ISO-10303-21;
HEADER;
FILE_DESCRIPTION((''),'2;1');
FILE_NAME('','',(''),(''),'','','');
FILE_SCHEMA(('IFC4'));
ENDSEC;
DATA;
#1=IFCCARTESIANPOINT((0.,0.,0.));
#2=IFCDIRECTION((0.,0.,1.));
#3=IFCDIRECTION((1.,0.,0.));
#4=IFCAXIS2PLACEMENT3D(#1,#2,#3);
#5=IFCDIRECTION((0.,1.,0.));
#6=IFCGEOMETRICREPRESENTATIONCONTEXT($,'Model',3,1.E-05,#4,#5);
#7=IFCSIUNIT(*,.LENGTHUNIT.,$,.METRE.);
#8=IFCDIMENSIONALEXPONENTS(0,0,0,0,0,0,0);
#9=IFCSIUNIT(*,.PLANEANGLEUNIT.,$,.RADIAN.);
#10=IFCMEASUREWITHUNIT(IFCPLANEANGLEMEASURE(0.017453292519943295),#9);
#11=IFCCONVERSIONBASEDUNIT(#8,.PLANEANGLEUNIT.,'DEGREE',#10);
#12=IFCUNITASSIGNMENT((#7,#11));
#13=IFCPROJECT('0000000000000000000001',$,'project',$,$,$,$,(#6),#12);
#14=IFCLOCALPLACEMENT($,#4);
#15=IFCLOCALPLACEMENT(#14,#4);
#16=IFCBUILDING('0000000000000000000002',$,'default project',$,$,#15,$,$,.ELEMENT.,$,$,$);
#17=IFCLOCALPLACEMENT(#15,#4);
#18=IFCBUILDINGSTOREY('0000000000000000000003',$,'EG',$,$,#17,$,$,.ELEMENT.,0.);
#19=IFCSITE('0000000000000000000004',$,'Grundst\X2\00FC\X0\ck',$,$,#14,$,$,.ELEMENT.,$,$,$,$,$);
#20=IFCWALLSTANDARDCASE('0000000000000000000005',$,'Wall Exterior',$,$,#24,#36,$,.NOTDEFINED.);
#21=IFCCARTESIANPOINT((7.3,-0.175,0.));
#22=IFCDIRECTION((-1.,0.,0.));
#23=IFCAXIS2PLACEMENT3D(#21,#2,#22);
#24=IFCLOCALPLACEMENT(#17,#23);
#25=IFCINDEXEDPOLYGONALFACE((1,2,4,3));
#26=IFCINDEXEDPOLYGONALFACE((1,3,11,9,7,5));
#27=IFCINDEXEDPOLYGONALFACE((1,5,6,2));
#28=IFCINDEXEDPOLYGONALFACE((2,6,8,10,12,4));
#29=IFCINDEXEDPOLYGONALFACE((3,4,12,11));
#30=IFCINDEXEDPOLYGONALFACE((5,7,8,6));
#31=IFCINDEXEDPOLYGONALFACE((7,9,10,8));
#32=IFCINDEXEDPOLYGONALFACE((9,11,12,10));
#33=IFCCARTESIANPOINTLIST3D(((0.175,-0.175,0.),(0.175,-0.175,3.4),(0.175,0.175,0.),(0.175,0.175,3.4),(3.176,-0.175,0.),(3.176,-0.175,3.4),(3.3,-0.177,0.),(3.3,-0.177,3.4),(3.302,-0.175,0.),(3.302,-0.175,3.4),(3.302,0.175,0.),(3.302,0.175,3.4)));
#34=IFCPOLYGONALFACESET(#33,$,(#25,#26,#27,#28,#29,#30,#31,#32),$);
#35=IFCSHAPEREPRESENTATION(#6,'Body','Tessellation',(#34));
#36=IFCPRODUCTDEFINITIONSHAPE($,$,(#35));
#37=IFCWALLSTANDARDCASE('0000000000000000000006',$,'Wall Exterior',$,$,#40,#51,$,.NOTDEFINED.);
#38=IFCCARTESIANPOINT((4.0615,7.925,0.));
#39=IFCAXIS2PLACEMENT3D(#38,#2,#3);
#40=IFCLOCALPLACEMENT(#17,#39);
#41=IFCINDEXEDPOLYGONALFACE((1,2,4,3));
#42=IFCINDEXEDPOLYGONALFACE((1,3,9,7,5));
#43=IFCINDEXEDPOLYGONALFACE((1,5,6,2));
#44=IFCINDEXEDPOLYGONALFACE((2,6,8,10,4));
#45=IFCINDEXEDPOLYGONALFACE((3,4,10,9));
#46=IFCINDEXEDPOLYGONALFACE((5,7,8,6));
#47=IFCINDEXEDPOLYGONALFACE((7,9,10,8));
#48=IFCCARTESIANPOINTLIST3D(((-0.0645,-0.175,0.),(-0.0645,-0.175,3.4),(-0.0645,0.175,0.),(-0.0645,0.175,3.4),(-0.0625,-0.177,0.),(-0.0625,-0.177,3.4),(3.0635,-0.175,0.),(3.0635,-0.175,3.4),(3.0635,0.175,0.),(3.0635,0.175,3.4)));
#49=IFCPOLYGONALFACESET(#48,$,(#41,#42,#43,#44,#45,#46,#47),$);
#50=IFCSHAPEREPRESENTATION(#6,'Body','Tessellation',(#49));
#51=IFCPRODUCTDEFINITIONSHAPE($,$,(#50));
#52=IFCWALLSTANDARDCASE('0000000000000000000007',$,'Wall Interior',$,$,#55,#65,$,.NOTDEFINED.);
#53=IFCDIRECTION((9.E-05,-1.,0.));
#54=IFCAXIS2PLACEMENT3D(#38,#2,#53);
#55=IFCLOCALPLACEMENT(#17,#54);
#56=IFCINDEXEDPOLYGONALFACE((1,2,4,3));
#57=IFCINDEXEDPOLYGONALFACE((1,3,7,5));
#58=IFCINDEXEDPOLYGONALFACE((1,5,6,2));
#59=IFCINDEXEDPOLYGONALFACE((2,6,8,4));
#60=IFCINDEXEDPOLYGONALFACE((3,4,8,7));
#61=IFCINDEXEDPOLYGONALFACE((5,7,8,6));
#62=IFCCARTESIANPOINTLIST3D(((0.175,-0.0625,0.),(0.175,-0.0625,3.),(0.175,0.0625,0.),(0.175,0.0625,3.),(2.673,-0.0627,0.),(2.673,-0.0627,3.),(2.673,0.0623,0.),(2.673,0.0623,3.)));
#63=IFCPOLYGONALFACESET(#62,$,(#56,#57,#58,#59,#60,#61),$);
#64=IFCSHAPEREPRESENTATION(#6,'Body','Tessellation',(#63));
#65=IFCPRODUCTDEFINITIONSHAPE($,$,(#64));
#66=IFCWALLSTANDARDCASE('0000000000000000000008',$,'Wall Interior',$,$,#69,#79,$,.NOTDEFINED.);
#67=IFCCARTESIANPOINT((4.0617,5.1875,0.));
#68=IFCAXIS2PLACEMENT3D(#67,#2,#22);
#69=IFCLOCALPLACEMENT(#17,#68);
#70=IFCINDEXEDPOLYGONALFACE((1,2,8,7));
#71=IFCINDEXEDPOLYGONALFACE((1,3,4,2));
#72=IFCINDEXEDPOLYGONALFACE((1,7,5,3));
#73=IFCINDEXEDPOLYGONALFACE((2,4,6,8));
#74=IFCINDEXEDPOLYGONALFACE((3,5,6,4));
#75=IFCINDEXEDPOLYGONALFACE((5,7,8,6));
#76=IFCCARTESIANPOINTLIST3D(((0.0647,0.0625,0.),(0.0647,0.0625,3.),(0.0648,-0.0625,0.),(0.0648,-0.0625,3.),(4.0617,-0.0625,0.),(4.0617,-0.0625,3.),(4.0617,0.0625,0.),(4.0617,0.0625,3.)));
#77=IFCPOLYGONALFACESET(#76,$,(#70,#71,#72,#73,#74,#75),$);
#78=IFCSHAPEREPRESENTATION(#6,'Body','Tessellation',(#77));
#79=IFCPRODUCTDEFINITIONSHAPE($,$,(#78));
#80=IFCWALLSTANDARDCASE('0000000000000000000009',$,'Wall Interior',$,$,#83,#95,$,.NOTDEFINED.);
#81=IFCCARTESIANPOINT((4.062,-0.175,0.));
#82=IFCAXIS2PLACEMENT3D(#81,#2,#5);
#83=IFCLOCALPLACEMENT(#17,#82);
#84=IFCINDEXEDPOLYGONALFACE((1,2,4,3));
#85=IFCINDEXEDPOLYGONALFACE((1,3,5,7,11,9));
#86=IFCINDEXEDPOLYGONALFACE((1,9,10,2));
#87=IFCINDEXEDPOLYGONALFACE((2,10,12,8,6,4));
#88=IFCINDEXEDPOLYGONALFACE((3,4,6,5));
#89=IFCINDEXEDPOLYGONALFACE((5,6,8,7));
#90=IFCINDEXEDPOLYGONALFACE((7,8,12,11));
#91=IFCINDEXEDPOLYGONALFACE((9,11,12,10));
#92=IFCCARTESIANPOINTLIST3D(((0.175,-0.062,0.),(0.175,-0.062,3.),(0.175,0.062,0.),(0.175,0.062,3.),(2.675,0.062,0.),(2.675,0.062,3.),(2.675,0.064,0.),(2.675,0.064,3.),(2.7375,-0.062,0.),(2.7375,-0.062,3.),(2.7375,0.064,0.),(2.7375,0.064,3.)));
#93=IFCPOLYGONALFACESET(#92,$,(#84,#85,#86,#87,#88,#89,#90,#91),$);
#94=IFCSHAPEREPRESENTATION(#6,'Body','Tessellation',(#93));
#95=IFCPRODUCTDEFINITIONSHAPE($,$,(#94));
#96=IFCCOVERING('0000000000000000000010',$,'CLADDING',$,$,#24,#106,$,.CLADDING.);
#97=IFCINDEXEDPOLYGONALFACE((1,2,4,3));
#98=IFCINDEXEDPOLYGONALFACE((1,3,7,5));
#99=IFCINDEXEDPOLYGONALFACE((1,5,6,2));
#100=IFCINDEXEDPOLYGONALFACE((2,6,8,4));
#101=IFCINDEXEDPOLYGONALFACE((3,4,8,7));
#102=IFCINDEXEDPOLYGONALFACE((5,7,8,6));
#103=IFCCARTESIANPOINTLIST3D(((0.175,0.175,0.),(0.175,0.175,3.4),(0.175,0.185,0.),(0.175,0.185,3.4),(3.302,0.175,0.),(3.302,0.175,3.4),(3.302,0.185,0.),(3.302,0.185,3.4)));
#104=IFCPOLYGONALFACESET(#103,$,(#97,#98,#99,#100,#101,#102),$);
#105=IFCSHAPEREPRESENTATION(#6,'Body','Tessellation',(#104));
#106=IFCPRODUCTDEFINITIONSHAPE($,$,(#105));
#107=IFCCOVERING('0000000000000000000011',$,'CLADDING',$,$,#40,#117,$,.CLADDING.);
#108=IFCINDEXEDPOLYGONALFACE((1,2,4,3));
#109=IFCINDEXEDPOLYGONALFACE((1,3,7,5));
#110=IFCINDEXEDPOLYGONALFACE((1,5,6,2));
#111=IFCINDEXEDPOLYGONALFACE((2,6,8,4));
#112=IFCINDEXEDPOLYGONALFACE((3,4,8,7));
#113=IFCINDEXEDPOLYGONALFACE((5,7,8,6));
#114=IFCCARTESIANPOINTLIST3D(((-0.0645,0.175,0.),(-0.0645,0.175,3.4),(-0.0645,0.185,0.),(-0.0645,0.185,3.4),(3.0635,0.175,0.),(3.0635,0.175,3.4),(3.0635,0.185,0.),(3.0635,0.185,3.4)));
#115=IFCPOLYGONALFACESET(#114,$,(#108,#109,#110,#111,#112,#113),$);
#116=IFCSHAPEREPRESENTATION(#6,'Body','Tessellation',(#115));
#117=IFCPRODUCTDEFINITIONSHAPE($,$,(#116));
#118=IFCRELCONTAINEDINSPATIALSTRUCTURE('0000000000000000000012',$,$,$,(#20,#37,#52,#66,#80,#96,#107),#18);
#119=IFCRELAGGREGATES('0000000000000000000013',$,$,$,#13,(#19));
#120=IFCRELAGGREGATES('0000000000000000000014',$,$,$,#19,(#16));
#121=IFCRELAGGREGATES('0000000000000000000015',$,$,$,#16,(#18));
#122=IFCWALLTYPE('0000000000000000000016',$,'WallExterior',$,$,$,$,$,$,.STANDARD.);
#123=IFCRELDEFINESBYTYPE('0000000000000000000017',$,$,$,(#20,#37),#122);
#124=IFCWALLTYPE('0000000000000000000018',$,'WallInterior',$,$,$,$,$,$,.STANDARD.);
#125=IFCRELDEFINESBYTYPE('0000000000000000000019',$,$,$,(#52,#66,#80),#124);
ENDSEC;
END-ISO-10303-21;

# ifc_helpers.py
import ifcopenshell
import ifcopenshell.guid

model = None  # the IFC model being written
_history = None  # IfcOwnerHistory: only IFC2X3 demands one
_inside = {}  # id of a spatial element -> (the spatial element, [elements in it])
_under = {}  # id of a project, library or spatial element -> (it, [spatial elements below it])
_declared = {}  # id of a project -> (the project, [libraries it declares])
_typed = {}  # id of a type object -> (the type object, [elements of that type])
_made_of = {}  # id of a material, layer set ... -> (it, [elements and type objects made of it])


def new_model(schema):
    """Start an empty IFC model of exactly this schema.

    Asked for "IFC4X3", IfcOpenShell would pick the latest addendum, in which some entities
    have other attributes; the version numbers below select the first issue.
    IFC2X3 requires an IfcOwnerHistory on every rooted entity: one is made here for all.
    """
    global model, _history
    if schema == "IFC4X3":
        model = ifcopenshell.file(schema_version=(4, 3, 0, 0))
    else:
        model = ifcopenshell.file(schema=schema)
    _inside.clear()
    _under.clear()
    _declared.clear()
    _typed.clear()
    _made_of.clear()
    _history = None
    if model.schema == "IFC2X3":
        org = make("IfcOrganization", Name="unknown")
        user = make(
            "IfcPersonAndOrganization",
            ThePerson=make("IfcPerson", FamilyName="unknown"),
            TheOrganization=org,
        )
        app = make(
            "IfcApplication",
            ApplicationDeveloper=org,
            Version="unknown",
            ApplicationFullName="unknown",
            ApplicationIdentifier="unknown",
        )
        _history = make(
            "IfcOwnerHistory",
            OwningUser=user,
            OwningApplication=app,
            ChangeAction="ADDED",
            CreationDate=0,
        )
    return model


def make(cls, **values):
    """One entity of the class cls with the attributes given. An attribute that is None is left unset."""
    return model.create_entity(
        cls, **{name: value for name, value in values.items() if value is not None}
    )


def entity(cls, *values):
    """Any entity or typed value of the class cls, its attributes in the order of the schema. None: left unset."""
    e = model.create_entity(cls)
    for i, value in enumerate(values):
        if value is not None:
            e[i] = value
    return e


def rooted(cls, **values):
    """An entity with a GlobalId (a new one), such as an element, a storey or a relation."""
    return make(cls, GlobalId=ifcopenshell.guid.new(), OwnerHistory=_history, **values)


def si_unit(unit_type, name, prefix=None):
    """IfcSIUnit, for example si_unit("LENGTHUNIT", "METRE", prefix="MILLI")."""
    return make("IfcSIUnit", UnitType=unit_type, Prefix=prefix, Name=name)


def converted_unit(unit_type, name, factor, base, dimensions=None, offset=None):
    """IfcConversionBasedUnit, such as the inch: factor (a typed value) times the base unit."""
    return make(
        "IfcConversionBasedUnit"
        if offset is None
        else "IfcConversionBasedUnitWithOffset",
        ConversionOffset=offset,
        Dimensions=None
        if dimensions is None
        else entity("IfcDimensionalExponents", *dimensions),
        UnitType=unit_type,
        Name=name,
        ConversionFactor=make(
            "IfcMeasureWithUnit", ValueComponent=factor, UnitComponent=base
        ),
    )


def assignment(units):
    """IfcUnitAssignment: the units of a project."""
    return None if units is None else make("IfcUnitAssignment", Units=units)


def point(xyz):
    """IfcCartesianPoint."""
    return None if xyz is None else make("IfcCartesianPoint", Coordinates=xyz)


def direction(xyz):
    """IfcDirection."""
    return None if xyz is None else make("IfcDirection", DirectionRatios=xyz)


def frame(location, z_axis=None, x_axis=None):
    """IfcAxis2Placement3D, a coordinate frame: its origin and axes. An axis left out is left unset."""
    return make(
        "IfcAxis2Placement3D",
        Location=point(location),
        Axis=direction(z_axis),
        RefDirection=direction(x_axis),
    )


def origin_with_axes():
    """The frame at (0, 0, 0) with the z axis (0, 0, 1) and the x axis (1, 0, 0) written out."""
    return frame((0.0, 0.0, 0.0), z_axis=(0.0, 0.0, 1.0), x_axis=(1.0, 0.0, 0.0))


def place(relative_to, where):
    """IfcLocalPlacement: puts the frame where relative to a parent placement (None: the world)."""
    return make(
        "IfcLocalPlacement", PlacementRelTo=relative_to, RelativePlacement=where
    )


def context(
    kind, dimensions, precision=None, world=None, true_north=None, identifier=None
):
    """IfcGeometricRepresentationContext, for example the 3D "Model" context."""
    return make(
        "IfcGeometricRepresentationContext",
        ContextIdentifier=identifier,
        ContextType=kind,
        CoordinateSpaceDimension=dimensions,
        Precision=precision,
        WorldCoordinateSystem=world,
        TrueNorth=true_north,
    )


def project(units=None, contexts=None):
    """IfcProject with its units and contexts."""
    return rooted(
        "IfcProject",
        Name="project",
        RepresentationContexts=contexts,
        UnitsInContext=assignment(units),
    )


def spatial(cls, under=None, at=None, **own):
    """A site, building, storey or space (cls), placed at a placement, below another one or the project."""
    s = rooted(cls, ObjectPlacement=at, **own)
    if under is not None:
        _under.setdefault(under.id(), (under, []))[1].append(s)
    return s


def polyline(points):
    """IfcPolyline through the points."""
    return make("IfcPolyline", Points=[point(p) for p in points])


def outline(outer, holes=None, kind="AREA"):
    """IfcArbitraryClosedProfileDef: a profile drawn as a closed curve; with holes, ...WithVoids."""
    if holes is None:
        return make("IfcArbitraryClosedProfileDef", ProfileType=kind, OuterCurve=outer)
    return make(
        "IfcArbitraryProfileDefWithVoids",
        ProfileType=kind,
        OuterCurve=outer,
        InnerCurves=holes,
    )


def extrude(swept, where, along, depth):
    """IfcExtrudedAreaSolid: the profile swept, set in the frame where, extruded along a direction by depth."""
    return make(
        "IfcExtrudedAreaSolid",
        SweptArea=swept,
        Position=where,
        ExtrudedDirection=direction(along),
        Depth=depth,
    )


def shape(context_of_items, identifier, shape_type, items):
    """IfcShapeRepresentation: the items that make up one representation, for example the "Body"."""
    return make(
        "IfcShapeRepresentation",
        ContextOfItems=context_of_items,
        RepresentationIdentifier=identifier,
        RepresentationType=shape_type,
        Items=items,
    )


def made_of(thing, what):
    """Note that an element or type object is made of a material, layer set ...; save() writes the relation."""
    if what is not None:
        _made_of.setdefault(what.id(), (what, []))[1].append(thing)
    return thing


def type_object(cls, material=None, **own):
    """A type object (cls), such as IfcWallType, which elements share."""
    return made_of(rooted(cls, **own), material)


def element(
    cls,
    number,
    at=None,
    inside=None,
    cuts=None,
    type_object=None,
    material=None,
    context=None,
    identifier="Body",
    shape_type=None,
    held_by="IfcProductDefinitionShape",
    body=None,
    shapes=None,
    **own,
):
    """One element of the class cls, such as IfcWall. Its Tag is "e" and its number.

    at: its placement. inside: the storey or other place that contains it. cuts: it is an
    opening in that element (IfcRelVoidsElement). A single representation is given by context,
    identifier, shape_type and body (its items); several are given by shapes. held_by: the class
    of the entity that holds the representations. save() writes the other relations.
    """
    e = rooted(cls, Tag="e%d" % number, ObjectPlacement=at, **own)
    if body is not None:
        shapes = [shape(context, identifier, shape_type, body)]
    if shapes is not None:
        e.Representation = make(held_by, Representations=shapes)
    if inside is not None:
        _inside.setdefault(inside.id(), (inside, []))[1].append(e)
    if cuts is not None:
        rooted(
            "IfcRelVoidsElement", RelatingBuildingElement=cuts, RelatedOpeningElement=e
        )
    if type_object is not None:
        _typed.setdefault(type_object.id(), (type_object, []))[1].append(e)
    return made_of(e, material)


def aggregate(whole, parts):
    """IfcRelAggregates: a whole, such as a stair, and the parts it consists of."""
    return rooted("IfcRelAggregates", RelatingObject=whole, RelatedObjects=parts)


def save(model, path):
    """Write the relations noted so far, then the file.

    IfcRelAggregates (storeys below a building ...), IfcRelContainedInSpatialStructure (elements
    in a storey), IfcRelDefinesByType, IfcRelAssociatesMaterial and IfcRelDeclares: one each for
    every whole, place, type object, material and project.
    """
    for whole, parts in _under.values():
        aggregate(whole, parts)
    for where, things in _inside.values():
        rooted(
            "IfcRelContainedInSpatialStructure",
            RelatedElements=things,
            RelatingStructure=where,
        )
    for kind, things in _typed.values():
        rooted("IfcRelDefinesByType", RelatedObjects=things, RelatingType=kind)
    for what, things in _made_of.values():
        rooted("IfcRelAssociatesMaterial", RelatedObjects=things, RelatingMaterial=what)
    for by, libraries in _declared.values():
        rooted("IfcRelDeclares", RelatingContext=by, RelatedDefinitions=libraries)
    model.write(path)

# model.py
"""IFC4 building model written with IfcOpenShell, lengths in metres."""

from ifc_helpers import new_model, entity, si_unit, converted_unit, direction, frame, origin_with_axes, place, context, project, spatial, polyline, outline, extrude, type_object, element, save


model = new_model("IFC4")

# Units and contexts
model_context = context("Model", 3, precision=1e-05, world=origin_with_axes(), true_north=direction((0.0, 1.0, 0.0)))
ifc_project = project(units=[si_unit("LENGTHUNIT", "METRE"), converted_unit("PLANEANGLEUNIT", "DEGREE", entity("IfcPlaneAngleMeasure", 0.017453292519943295), si_unit("PLANEANGLEUNIT", "RADIAN"), dimensions=[0, 0, 0, 0, 0, 0, 0])], contexts=[model_context])

# Site, building, storey
site_placement = place(None, origin_with_axes())
site = spatial("IfcSite", under=ifc_project, at=site_placement, Name="Grundstück", CompositionType="ELEMENT")
building_placement = place(site_placement, origin_with_axes())
building = spatial("IfcBuilding", under=site, at=building_placement, Name="default project", CompositionType="ELEMENT")
placement_1 = place(building_placement, origin_with_axes())
storey = spatial("IfcBuildingStorey", under=building, at=placement_1, Name="EG", CompositionType="ELEMENT", Elevation=0.0)

# Walls
wall_type_1 = type_object("IfcWallType", Name="WallExterior", PredefinedType="STANDARD")
placement_2 = place(placement_1, frame((7.3, -0.175, 0.0), z_axis=(0.0, 0.0, 1.0), x_axis=(-1.0, 0.0, 0.0)))
element("IfcWallStandardCase", 1, at=placement_2, inside=storey, type_object=wall_type_1, Name="Wall Exterior", PredefinedType="NOTDEFINED", context=model_context, shape_type="SweptSolid", body=[
    extrude(outline(polyline([(3.302, -0.175), (3.302, 0.175), (0.175, 0.175), (0.175, -0.175), (3.176, -0.175), (3.3, -0.177), (3.302, -0.175)])), origin_with_axes(), (0.0, 0.0, 1.0), 3.4),
])
placement_3 = place(placement_1, frame((4.0615, 7.925, 0.0), z_axis=(0.0, 0.0, 1.0), x_axis=(1.0, 0.0, 0.0)))
element("IfcWallStandardCase", 2, at=placement_3, inside=storey, type_object=wall_type_1, Name="Wall Exterior", PredefinedType="NOTDEFINED", context=model_context, shape_type="SweptSolid", body=[
    extrude(outline(polyline([(-0.0645, 0.175), (-0.0645, -0.175), (-0.0625, -0.177), (3.0635, -0.175), (3.0635, 0.175), (-0.0645, 0.175)])), origin_with_axes(), (0.0, 0.0, 1.0), 3.4),
])
wall_type_2 = type_object("IfcWallType", Name="WallInterior", PredefinedType="STANDARD")
wall_1_placement = place(placement_1, frame((4.0615, 7.925, 0.0), z_axis=(0.0, 0.0, 1.0), x_axis=(0.00009, -1.0, 0.0)))
element("IfcWallStandardCase", 3, at=wall_1_placement, inside=storey, type_object=wall_type_2, Name="Wall Interior", PredefinedType="NOTDEFINED", context=model_context, shape_type="SweptSolid", body=[
    extrude(outline(polyline([(0.175, 0.0625), (0.175, -0.0625), (2.673, -0.0627), (2.673, 0.0623), (0.175, 0.0625)])), origin_with_axes(), (0.0, 0.0, 1.0), 3.0),
])
wall_2_placement = place(placement_1, frame((4.0617, 5.1875, 0.0), z_axis=(0.0, 0.0, 1.0), x_axis=(-1.0, 0.0, 0.0)))
element("IfcWallStandardCase", 4, at=wall_2_placement, inside=storey, type_object=wall_type_2, Name="Wall Interior", PredefinedType="NOTDEFINED", context=model_context, shape_type="SweptSolid", body=[
    extrude(outline(polyline([(0.0647, 0.0625), (0.0648, -0.0625), (4.0617, -0.0625), (4.0617, 0.0625), (0.0647, 0.0625)])), origin_with_axes(), (0.0, 0.0, 1.0), 3.0),
])
wall_3_placement = place(placement_1, frame((4.062, -0.175, 0.0), z_axis=(0.0, 0.0, 1.0), x_axis=(0.0, 1.0, 0.0)))
element("IfcWallStandardCase", 5, at=wall_3_placement, inside=storey, type_object=wall_type_2, Name="Wall Interior", PredefinedType="NOTDEFINED", context=model_context, shape_type="SweptSolid", body=[
    extrude(outline(polyline([(2.675, 0.064), (2.675, 0.062), (0.175, 0.062), (0.175, -0.062), (2.7375, -0.062), (2.7375, 0.064), (2.675, 0.064)])), origin_with_axes(), (0.0, 0.0, 1.0), 3.0),
])

# Coverings
element("IfcCovering", 6, at=placement_2, inside=storey, Name="CLADDING", PredefinedType="CLADDING", context=model_context, shape_type="SweptSolid", body=[
    extrude(outline(polyline([(3.302, 0.185), (0.175, 0.185), (0.175, 0.175), (3.302, 0.175), (3.302, 0.185)])), origin_with_axes(), (0.0, 0.0, 1.0), 3.4),
])
element("IfcCovering", 7, at=placement_3, inside=storey, Name="CLADDING", PredefinedType="CLADDING", context=model_context, shape_type="SweptSolid", body=[
    extrude(outline(polyline([(3.0635, 0.185), (-0.0645, 0.185), (-0.0645, 0.175), (3.0635, 0.175), (3.0635, 0.185)])), origin_with_axes(), (0.0, 0.0, 1.0), 3.4),
])

save(model, "model.ifc")
